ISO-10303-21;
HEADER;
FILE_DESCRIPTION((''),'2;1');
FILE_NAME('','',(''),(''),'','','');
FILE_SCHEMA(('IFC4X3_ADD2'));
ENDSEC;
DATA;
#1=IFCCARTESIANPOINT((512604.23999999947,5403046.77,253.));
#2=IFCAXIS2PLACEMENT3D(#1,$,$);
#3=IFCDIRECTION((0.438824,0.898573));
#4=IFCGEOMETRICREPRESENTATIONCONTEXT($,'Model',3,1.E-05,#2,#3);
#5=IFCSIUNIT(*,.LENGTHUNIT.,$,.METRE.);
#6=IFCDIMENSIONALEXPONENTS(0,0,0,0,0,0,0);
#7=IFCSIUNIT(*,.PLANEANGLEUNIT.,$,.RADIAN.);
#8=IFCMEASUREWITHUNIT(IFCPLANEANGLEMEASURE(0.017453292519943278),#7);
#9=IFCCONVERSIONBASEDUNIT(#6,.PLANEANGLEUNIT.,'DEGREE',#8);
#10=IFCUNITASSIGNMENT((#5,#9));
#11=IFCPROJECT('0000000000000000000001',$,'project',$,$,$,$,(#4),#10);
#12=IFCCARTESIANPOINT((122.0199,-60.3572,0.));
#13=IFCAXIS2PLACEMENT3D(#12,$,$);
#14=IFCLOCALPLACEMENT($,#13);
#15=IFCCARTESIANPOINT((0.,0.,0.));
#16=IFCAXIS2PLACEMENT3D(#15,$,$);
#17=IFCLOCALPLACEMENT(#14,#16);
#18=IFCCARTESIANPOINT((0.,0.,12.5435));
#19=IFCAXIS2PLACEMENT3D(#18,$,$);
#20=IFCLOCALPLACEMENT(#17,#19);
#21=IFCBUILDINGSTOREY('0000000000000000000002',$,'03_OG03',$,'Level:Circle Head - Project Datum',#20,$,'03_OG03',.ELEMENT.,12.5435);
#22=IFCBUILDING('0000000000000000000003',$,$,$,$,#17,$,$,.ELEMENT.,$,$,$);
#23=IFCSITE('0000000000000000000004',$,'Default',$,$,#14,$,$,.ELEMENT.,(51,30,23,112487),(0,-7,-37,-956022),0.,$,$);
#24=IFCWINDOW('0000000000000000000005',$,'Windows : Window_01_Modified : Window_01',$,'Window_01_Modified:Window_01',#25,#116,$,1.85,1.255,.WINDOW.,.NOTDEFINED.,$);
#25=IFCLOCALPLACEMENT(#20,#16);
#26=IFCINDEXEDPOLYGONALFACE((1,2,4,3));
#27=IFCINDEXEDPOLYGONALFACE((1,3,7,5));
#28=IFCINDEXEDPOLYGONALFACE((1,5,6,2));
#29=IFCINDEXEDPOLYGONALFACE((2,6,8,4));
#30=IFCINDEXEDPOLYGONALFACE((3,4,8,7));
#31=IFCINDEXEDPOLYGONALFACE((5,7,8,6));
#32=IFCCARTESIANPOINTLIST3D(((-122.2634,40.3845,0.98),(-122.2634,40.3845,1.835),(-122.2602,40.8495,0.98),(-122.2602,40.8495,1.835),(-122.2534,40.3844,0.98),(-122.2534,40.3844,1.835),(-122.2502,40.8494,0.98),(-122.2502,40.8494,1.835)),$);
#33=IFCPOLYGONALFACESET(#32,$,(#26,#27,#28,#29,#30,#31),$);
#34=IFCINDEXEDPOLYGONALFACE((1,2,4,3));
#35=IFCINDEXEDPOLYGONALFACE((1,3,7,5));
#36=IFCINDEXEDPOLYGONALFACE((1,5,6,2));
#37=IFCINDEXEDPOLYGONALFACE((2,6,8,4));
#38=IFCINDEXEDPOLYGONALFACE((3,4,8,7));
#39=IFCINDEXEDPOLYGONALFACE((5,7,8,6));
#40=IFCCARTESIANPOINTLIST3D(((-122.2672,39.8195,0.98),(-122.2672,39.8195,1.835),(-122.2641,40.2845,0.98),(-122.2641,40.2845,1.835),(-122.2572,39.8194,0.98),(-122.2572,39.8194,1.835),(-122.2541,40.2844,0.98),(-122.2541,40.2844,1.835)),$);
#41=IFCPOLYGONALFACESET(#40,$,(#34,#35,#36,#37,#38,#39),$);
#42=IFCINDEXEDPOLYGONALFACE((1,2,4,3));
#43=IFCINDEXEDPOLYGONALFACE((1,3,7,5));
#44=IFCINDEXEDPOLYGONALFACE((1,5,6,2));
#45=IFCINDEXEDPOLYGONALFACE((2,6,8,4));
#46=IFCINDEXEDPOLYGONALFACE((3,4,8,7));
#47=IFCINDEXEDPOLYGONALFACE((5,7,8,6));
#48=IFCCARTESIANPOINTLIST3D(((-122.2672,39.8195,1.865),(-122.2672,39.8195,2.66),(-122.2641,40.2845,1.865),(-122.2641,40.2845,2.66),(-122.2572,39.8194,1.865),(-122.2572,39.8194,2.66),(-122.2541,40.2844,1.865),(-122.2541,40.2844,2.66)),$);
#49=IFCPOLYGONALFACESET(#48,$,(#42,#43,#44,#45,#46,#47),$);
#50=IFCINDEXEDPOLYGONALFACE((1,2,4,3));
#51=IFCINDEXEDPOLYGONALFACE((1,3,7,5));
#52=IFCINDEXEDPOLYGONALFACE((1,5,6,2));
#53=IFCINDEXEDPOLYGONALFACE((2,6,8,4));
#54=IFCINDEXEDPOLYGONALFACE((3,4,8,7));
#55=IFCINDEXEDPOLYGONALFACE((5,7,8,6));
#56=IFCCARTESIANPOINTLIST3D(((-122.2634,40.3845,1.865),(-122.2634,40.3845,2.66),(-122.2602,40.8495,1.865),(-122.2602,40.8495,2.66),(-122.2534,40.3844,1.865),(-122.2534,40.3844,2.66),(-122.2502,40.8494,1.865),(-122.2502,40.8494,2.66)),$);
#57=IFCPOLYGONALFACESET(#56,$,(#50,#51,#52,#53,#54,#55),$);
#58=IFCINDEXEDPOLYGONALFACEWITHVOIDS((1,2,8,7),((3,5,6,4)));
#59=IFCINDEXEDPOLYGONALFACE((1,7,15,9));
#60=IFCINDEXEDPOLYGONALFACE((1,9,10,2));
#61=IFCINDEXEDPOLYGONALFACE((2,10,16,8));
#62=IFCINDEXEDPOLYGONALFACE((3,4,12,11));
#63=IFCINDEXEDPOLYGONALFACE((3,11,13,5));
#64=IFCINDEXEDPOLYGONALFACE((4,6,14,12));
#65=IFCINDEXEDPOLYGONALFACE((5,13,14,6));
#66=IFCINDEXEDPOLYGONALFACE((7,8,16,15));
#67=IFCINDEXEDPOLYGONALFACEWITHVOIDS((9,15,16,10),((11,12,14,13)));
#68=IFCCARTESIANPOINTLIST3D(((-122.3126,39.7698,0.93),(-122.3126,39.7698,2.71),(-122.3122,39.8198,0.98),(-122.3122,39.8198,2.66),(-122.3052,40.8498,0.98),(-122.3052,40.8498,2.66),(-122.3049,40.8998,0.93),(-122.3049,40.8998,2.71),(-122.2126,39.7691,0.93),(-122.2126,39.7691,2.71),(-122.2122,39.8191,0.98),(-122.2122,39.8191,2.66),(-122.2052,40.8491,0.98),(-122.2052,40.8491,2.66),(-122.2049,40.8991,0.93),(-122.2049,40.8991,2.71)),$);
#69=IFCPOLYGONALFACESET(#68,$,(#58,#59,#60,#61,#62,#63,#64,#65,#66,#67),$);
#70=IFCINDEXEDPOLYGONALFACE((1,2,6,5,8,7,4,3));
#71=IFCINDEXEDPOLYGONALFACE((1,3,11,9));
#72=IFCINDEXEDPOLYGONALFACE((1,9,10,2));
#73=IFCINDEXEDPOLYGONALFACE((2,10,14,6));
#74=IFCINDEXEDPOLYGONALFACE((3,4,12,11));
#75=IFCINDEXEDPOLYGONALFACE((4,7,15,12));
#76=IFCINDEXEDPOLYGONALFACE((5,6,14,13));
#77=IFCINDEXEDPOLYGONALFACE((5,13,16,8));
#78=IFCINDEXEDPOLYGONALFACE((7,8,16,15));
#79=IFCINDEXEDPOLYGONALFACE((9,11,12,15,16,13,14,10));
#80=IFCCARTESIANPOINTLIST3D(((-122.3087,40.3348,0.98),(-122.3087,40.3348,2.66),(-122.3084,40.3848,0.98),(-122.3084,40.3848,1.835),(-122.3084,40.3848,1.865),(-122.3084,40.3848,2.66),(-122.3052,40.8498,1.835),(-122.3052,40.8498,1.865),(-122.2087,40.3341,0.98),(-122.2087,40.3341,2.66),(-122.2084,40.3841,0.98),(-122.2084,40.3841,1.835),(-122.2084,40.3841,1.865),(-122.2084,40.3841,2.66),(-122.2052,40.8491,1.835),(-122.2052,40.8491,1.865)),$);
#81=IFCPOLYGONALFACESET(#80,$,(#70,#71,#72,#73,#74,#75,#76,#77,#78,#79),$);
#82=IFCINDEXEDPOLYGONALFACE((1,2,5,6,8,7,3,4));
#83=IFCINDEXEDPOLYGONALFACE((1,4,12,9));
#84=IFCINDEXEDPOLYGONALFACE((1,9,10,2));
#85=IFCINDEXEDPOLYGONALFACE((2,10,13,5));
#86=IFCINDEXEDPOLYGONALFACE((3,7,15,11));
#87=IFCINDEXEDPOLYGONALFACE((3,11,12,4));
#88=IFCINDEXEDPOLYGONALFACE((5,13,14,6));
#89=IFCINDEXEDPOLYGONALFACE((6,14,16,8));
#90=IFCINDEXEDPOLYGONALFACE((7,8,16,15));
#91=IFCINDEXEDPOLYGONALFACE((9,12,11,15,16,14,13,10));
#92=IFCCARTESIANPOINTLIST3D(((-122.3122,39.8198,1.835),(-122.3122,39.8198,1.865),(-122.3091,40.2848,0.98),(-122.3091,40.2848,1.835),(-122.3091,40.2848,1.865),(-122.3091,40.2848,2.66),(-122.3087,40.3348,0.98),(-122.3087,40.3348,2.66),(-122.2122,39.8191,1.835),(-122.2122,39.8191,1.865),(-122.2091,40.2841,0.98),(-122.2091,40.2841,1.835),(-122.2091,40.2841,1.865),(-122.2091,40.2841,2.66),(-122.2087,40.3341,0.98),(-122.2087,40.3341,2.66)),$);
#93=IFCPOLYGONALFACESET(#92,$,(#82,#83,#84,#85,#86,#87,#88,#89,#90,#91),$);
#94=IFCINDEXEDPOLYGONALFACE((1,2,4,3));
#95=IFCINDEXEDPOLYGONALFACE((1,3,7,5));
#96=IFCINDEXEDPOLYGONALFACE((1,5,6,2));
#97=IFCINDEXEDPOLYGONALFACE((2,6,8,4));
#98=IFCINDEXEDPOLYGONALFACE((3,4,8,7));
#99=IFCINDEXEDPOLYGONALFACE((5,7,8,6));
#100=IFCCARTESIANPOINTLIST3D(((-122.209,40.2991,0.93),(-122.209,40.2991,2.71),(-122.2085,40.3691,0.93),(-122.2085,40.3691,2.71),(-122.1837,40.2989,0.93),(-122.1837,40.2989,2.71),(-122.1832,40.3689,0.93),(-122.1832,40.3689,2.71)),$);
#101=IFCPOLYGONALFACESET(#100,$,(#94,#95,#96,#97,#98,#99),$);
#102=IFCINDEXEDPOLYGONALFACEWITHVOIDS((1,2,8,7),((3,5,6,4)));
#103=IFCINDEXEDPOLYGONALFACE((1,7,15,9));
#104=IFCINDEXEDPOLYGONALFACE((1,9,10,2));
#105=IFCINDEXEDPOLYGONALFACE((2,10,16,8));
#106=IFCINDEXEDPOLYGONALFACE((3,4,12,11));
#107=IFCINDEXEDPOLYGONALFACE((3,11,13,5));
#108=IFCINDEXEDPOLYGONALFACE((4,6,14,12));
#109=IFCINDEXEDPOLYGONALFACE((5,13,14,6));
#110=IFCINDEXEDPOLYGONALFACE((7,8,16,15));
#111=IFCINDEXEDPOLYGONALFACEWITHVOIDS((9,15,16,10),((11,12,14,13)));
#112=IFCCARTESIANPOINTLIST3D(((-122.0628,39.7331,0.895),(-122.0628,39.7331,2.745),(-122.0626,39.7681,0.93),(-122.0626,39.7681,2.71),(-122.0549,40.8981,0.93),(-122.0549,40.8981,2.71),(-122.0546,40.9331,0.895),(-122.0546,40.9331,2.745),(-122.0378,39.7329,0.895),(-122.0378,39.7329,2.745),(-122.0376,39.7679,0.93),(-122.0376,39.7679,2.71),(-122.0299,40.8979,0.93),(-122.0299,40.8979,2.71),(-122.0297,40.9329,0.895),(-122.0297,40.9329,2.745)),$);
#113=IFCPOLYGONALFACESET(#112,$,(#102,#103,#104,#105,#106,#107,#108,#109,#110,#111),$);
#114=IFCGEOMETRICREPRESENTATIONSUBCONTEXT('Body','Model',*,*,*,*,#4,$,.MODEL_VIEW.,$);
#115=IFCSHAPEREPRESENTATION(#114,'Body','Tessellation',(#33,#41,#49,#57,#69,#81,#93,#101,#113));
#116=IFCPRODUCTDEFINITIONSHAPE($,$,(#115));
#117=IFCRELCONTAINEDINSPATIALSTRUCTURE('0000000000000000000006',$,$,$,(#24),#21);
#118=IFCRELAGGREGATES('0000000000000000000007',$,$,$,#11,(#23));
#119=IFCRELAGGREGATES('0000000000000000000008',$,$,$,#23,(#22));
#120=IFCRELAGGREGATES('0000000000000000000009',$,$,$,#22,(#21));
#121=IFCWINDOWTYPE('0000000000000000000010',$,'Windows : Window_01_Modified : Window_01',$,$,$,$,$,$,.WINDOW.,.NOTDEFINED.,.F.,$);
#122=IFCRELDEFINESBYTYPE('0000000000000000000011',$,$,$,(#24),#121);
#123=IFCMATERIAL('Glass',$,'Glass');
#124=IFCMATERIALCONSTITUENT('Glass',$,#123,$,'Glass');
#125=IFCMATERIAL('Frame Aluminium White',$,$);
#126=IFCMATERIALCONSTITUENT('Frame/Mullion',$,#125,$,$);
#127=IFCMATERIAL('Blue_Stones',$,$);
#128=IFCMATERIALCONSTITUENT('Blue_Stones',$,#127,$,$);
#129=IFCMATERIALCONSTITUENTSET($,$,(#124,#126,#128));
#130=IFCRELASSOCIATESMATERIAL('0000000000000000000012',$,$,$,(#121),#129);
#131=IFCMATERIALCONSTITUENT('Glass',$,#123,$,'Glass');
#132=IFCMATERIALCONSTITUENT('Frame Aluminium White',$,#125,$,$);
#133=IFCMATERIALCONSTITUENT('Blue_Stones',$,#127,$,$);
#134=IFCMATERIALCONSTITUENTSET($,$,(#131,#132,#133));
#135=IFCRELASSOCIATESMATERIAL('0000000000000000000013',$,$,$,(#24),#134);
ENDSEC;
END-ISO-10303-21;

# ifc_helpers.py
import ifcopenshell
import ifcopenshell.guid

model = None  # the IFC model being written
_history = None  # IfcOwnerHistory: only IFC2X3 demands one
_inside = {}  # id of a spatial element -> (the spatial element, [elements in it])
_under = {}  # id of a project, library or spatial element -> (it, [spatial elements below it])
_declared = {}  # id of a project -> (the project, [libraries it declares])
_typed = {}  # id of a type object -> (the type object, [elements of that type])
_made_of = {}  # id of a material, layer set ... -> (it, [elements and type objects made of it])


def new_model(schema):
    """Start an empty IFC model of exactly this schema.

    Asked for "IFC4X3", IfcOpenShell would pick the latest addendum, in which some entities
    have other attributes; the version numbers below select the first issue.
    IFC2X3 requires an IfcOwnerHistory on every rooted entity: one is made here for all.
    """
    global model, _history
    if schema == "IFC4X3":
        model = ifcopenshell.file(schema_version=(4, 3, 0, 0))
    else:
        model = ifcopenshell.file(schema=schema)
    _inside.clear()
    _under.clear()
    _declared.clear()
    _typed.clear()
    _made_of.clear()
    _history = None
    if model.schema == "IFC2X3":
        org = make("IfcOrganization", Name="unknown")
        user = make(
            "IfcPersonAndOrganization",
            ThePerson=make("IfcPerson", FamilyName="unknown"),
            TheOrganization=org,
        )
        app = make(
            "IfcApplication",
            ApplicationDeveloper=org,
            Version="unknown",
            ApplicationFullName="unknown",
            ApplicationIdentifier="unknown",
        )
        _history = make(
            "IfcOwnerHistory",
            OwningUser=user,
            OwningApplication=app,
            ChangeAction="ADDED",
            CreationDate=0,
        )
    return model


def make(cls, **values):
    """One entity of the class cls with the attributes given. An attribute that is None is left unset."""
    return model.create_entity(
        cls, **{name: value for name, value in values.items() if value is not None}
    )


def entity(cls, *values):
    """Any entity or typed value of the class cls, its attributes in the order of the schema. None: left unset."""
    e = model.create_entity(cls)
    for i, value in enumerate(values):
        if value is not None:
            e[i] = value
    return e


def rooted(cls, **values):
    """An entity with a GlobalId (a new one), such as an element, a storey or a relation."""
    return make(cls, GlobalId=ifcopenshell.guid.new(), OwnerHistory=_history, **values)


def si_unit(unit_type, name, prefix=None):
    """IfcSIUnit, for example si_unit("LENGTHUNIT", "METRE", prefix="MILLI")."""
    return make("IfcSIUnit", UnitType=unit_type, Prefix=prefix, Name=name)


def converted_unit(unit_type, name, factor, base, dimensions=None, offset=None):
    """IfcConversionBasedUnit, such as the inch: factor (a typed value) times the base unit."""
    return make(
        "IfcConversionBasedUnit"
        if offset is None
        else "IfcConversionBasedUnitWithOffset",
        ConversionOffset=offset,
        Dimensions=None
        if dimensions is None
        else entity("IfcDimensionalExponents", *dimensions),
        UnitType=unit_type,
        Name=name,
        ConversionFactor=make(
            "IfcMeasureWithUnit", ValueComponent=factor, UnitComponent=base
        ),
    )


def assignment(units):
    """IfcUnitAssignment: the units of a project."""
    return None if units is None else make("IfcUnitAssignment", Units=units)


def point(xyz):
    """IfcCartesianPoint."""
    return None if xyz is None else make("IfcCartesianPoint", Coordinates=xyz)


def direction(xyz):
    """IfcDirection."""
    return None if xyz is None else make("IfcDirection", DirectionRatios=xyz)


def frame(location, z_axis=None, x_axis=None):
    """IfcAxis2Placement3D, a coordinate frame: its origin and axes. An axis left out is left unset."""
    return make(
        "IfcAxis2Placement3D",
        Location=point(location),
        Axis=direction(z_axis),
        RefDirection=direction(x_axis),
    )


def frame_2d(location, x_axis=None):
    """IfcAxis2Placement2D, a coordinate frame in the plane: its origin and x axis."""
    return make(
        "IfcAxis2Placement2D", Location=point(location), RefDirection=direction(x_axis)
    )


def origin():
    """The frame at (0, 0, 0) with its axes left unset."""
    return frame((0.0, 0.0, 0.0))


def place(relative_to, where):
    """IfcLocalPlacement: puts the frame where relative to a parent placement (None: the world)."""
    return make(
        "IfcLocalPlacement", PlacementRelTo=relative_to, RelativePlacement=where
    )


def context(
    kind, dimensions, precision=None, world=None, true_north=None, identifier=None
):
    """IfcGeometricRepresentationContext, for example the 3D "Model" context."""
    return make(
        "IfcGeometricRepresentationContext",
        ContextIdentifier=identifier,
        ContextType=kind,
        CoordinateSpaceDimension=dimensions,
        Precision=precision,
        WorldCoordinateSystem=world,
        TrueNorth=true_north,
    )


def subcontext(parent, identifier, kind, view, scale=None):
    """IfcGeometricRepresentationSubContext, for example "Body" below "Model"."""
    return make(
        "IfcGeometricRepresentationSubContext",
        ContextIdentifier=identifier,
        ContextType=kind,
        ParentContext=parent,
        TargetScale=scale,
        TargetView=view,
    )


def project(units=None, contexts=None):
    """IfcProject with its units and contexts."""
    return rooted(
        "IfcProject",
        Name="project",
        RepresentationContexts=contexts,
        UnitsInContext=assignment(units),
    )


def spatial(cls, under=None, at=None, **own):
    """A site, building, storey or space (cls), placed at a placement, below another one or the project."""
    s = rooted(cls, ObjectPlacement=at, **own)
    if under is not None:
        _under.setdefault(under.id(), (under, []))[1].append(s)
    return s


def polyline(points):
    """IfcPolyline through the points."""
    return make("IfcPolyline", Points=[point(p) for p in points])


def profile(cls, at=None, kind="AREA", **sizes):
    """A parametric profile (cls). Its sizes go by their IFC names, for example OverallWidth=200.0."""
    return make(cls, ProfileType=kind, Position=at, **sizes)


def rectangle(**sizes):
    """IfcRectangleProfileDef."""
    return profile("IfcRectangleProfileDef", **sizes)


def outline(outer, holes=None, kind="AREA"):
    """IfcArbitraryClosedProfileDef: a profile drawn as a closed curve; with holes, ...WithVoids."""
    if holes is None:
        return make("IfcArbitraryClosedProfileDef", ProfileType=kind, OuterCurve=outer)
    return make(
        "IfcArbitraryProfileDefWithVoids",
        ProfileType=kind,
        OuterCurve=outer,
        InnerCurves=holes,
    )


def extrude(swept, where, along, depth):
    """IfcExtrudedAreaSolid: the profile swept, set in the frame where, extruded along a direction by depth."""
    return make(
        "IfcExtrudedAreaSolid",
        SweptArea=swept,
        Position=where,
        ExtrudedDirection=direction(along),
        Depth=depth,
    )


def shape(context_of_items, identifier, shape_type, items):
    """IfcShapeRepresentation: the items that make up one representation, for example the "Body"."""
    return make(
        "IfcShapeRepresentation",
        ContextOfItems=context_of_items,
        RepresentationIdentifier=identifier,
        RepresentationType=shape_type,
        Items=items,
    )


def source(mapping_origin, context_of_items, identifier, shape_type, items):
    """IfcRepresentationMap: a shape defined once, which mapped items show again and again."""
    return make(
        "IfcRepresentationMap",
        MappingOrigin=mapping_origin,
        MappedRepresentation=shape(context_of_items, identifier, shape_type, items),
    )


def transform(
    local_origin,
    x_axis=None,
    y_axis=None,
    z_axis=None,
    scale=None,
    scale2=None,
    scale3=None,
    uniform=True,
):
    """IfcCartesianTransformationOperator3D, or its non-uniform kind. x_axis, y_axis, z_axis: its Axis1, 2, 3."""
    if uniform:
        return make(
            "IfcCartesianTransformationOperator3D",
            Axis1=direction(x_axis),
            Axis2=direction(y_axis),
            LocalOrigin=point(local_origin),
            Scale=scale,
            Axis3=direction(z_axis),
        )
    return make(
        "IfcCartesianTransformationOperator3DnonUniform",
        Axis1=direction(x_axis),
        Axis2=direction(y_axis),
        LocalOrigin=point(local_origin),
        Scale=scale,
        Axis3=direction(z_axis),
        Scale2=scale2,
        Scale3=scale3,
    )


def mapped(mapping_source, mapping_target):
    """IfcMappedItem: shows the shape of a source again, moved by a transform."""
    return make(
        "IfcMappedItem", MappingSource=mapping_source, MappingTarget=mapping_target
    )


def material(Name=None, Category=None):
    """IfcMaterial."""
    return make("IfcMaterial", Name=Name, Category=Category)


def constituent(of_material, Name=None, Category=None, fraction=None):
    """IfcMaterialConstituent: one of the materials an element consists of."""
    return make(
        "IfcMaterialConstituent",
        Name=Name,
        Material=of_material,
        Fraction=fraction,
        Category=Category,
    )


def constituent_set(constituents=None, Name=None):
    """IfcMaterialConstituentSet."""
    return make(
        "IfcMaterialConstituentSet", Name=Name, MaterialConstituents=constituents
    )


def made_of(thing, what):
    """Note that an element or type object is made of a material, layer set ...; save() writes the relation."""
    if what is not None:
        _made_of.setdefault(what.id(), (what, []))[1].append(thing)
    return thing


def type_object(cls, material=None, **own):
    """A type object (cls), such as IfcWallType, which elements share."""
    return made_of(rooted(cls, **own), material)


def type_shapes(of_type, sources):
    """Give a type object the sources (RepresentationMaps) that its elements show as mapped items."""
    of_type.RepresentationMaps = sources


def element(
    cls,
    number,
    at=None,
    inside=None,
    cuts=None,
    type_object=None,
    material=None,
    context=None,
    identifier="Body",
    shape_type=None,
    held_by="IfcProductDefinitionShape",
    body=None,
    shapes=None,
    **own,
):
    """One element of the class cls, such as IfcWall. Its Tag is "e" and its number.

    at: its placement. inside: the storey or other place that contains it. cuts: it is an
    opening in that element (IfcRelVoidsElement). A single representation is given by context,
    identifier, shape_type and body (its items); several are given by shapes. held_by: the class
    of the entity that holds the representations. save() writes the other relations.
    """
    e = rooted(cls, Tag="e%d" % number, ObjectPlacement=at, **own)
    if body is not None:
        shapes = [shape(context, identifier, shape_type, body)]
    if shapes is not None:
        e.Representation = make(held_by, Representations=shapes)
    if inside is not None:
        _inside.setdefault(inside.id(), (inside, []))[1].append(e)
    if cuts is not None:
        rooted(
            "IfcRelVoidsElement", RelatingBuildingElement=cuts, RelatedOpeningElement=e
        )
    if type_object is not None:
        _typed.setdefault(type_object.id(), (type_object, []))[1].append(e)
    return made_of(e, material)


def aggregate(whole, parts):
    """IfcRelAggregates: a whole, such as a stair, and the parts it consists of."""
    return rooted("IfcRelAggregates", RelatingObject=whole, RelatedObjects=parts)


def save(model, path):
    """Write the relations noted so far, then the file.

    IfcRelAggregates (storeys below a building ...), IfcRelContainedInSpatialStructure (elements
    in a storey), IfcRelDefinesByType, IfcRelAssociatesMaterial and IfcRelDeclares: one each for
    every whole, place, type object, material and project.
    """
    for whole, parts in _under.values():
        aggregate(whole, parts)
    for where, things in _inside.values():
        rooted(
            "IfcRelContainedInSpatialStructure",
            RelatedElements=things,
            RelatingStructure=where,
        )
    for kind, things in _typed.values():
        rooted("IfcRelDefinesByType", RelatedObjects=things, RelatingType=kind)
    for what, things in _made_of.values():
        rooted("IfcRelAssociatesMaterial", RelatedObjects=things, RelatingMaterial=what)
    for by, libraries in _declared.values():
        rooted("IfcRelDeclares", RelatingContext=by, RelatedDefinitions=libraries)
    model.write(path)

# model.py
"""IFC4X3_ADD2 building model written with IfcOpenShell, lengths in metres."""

from ifc_helpers import new_model, entity, si_unit, converted_unit, direction, frame, frame_2d, origin, place, context, subcontext, project, spatial, polyline, rectangle, outline, extrude, source, transform, mapped, material, constituent, constituent_set, type_object, type_shapes, element, save


model = new_model("IFC4X3_ADD2")

# Units and contexts
model_context = context("Model", 3, precision=1e-05, world=frame((512604.23999999947, 5403046.77, 253.0)), true_north=direction((0.438824, 0.898573)))
body_context = subcontext(model_context, "Body", "Model", "MODEL_VIEW")
ifc_project = project(units=[si_unit("LENGTHUNIT", "METRE"), converted_unit("PLANEANGLEUNIT", "DEGREE", entity("IfcPlaneAngleMeasure", 0.017453292519943278), si_unit("PLANEANGLEUNIT", "RADIAN"), dimensions=[0, 0, 0, 0, 0, 0, 0])], contexts=[model_context])

# Site, building, storey
site_placement = place(None, frame((122.0199, -60.3572, 0.0)))
site = spatial("IfcSite", under=ifc_project, at=site_placement, Name="Default", CompositionType="ELEMENT", RefLatitude=(51, 30, 23, 112487), RefLongitude=(0, -7, -37, -956022), RefElevation=0.0)
building_placement = place(site_placement, origin())
building = spatial("IfcBuilding", under=site, at=building_placement, CompositionType="ELEMENT")
storey_placement = place(building_placement, frame((0.0, 0.0, 12.5435)))
storey = spatial("IfcBuildingStorey", under=building, at=storey_placement, Name="03_OG03", ObjectType="Level:Circle Head - Project Datum", LongName="03_OG03", CompositionType="ELEMENT", Elevation=12.5435)

# Window
ifc_material_1 = material(Name="Glass", Category="Glass")
ifc_material_2 = material(Name="Frame Aluminium White")
ifc_material_3 = material(Name="Blue_Stones")
ifc_constituent_1 = constituent(ifc_material_1, Name="Glass", Category="Glass")
ifc_constituent_2 = constituent(ifc_material_2, Name="Frame Aluminium White")
ifc_constituent_3 = constituent(ifc_material_3, Name="Blue_Stones")
ifc_constituent_set_1 = constituent_set(constituents=[ifc_constituent_1, ifc_constituent_2, ifc_constituent_3])
ifc_constituent_4 = constituent(ifc_material_1, Name="Glass", Category="Glass")
ifc_constituent_5 = constituent(ifc_material_2, Name="Frame/Mullion")
ifc_constituent_6 = constituent(ifc_material_3, Name="Blue_Stones")
ifc_constituent_set_2 = constituent_set(constituents=[ifc_constituent_4, ifc_constituent_5, ifc_constituent_6])
window_type_1 = type_object("IfcWindowType", Name="Windows : Window_01_Modified : Window_01", ParameterTakesPrecedence=False, PartitioningType="NOTDEFINED", PredefinedType="WINDOW", material=ifc_constituent_set_2)
shared_shape_1 = source(origin(), body_context, "Body", "SweptSolid", [
    extrude(rectangle(XDim=0.465, YDim=0.01, at=frame_2d((0.0, 0.0), x_axis=(1.0, 0.0))), frame((0.3324, -0.2, 0.0514), z_axis=(0.0, 0.0, 1.0), x_axis=(-1.0, 0.0, 0.0)), (0.0, 0.0, 1.0), 0.855),
    extrude(rectangle(XDim=0.01, YDim=0.465, at=frame_2d((0.0, 0.0), x_axis=(1.0, 0.0))), frame((0.8974, -0.2, 0.0514), z_axis=(0.0, 0.0, 1.0), x_axis=(0.0, 1.0, 0.0)), (0.0, 0.0, 1.0), 0.855),
    extrude(rectangle(XDim=0.465, YDim=0.01, at=frame_2d((0.0, 0.0), x_axis=(1.0, 0.0))), frame((0.8974, -0.2, 0.9364), z_axis=(0.0, 0.0, 1.0), x_axis=(-1.0, 0.0, 0.0)), (0.0, 0.0, 1.0), 0.795),
    extrude(rectangle(XDim=0.465, YDim=0.01, at=frame_2d((0.0, 0.0), x_axis=(1.0, 0.0))), frame((0.3324, -0.2, 0.9364), z_axis=(0.0, 0.0, 1.0), x_axis=(-1.0, 0.0, 0.0)), (0.0, 0.0, 1.0), 0.795),
    extrude(outline(polyline([(-0.89, -0.565), (0.89, -0.565), (0.89, 0.565), (-0.89, 0.565), (-0.89, -0.565)]), holes=[polyline([(0.84, 0.515), (0.84, -0.515), (-0.84, -0.515), (-0.84, 0.515), (0.84, 0.515)])]), frame((0.6149, -0.25, 0.8914), z_axis=(0.0, 1.0, 0.0), x_axis=(0.0, 0.0, 1.0)), (0.0, 0.0, 1.0), 0.1),
    extrude(outline(polyline([(0.03, 0.1037), (0.825, 0.1037), (0.825, 0.1538), (-0.855, 0.1538), (-0.855, 0.1037), (0.0, 0.1037), (0.0, -0.3613), (0.03, -0.3613), (0.03, 0.1037)])), frame((0.4611, -0.25, 0.9064), z_axis=(0.0, 1.0, 0.0), x_axis=(0.0, 0.0, 1.0)), (0.0, 0.0, 1.0), 0.1),
    extrude(outline(polyline([(-0.825, -0.1038), (-0.825, -0.1538), (0.855, -0.1538), (0.855, -0.1038), (0.0, -0.1038), (0.0, 0.3613), (-0.03, 0.3613), (-0.03, -0.1038), (-0.825, -0.1038)])), frame((0.7686, -0.25, 0.9064), z_axis=(0.0, -1.0, 0.0), x_axis=(0.0, 0.0, -1.0)), (0.0, 0.0, -1.0), 0.1),
    extrude(rectangle(XDim=0.0253, YDim=0.07, at=frame_2d((0.0, 0.0), x_axis=(1.0, 0.0))), frame((0.6149, -0.1374, 0.0014), z_axis=(0.0, 0.0, 1.0), x_axis=(0.0, -1.0, 0.0)), (0.0, 0.0, 1.0), 1.78),
    extrude(outline(polyline([(-0.6, -0.925), (0.6, -0.925), (0.6, 0.925), (-0.6, 0.925), (-0.6, -0.925)]), holes=[polyline([(-0.565, -0.89), (-0.565, 0.89), (0.565, 0.89), (0.565, -0.89), (-0.565, -0.89)])]), frame((0.6149, 0.0, 0.8914), z_axis=(0.0, 1.0, 0.0), x_axis=(1.0, 0.0, 0.0)), (0.0, 0.0, 1.0), 0.025),
])
type_shapes(window_type_1, [shared_shape_1])
window_1_placement = place(storey_placement, frame((-122.0545, 40.948, 0.9286), z_axis=(0.0, 0.0, 1.0), x_axis=(-0.0068, -0.999977, 0.0)))
element("IfcWindow", 1, at=window_1_placement, inside=storey, type_object=window_type_1, material=ifc_constituent_set_1, Name="Windows : Window_01_Modified : Window_01", ObjectType="Window_01_Modified:Window_01", OverallHeight=1.85, OverallWidth=1.255, PartitioningType="NOTDEFINED", PredefinedType="WINDOW", context=body_context, shape_type="MappedRepresentation", body=[
    mapped(shared_shape_1, transform((0.0, 0.0, 0.0), scale=1.0)),
])

save(model, "model.ifc")
